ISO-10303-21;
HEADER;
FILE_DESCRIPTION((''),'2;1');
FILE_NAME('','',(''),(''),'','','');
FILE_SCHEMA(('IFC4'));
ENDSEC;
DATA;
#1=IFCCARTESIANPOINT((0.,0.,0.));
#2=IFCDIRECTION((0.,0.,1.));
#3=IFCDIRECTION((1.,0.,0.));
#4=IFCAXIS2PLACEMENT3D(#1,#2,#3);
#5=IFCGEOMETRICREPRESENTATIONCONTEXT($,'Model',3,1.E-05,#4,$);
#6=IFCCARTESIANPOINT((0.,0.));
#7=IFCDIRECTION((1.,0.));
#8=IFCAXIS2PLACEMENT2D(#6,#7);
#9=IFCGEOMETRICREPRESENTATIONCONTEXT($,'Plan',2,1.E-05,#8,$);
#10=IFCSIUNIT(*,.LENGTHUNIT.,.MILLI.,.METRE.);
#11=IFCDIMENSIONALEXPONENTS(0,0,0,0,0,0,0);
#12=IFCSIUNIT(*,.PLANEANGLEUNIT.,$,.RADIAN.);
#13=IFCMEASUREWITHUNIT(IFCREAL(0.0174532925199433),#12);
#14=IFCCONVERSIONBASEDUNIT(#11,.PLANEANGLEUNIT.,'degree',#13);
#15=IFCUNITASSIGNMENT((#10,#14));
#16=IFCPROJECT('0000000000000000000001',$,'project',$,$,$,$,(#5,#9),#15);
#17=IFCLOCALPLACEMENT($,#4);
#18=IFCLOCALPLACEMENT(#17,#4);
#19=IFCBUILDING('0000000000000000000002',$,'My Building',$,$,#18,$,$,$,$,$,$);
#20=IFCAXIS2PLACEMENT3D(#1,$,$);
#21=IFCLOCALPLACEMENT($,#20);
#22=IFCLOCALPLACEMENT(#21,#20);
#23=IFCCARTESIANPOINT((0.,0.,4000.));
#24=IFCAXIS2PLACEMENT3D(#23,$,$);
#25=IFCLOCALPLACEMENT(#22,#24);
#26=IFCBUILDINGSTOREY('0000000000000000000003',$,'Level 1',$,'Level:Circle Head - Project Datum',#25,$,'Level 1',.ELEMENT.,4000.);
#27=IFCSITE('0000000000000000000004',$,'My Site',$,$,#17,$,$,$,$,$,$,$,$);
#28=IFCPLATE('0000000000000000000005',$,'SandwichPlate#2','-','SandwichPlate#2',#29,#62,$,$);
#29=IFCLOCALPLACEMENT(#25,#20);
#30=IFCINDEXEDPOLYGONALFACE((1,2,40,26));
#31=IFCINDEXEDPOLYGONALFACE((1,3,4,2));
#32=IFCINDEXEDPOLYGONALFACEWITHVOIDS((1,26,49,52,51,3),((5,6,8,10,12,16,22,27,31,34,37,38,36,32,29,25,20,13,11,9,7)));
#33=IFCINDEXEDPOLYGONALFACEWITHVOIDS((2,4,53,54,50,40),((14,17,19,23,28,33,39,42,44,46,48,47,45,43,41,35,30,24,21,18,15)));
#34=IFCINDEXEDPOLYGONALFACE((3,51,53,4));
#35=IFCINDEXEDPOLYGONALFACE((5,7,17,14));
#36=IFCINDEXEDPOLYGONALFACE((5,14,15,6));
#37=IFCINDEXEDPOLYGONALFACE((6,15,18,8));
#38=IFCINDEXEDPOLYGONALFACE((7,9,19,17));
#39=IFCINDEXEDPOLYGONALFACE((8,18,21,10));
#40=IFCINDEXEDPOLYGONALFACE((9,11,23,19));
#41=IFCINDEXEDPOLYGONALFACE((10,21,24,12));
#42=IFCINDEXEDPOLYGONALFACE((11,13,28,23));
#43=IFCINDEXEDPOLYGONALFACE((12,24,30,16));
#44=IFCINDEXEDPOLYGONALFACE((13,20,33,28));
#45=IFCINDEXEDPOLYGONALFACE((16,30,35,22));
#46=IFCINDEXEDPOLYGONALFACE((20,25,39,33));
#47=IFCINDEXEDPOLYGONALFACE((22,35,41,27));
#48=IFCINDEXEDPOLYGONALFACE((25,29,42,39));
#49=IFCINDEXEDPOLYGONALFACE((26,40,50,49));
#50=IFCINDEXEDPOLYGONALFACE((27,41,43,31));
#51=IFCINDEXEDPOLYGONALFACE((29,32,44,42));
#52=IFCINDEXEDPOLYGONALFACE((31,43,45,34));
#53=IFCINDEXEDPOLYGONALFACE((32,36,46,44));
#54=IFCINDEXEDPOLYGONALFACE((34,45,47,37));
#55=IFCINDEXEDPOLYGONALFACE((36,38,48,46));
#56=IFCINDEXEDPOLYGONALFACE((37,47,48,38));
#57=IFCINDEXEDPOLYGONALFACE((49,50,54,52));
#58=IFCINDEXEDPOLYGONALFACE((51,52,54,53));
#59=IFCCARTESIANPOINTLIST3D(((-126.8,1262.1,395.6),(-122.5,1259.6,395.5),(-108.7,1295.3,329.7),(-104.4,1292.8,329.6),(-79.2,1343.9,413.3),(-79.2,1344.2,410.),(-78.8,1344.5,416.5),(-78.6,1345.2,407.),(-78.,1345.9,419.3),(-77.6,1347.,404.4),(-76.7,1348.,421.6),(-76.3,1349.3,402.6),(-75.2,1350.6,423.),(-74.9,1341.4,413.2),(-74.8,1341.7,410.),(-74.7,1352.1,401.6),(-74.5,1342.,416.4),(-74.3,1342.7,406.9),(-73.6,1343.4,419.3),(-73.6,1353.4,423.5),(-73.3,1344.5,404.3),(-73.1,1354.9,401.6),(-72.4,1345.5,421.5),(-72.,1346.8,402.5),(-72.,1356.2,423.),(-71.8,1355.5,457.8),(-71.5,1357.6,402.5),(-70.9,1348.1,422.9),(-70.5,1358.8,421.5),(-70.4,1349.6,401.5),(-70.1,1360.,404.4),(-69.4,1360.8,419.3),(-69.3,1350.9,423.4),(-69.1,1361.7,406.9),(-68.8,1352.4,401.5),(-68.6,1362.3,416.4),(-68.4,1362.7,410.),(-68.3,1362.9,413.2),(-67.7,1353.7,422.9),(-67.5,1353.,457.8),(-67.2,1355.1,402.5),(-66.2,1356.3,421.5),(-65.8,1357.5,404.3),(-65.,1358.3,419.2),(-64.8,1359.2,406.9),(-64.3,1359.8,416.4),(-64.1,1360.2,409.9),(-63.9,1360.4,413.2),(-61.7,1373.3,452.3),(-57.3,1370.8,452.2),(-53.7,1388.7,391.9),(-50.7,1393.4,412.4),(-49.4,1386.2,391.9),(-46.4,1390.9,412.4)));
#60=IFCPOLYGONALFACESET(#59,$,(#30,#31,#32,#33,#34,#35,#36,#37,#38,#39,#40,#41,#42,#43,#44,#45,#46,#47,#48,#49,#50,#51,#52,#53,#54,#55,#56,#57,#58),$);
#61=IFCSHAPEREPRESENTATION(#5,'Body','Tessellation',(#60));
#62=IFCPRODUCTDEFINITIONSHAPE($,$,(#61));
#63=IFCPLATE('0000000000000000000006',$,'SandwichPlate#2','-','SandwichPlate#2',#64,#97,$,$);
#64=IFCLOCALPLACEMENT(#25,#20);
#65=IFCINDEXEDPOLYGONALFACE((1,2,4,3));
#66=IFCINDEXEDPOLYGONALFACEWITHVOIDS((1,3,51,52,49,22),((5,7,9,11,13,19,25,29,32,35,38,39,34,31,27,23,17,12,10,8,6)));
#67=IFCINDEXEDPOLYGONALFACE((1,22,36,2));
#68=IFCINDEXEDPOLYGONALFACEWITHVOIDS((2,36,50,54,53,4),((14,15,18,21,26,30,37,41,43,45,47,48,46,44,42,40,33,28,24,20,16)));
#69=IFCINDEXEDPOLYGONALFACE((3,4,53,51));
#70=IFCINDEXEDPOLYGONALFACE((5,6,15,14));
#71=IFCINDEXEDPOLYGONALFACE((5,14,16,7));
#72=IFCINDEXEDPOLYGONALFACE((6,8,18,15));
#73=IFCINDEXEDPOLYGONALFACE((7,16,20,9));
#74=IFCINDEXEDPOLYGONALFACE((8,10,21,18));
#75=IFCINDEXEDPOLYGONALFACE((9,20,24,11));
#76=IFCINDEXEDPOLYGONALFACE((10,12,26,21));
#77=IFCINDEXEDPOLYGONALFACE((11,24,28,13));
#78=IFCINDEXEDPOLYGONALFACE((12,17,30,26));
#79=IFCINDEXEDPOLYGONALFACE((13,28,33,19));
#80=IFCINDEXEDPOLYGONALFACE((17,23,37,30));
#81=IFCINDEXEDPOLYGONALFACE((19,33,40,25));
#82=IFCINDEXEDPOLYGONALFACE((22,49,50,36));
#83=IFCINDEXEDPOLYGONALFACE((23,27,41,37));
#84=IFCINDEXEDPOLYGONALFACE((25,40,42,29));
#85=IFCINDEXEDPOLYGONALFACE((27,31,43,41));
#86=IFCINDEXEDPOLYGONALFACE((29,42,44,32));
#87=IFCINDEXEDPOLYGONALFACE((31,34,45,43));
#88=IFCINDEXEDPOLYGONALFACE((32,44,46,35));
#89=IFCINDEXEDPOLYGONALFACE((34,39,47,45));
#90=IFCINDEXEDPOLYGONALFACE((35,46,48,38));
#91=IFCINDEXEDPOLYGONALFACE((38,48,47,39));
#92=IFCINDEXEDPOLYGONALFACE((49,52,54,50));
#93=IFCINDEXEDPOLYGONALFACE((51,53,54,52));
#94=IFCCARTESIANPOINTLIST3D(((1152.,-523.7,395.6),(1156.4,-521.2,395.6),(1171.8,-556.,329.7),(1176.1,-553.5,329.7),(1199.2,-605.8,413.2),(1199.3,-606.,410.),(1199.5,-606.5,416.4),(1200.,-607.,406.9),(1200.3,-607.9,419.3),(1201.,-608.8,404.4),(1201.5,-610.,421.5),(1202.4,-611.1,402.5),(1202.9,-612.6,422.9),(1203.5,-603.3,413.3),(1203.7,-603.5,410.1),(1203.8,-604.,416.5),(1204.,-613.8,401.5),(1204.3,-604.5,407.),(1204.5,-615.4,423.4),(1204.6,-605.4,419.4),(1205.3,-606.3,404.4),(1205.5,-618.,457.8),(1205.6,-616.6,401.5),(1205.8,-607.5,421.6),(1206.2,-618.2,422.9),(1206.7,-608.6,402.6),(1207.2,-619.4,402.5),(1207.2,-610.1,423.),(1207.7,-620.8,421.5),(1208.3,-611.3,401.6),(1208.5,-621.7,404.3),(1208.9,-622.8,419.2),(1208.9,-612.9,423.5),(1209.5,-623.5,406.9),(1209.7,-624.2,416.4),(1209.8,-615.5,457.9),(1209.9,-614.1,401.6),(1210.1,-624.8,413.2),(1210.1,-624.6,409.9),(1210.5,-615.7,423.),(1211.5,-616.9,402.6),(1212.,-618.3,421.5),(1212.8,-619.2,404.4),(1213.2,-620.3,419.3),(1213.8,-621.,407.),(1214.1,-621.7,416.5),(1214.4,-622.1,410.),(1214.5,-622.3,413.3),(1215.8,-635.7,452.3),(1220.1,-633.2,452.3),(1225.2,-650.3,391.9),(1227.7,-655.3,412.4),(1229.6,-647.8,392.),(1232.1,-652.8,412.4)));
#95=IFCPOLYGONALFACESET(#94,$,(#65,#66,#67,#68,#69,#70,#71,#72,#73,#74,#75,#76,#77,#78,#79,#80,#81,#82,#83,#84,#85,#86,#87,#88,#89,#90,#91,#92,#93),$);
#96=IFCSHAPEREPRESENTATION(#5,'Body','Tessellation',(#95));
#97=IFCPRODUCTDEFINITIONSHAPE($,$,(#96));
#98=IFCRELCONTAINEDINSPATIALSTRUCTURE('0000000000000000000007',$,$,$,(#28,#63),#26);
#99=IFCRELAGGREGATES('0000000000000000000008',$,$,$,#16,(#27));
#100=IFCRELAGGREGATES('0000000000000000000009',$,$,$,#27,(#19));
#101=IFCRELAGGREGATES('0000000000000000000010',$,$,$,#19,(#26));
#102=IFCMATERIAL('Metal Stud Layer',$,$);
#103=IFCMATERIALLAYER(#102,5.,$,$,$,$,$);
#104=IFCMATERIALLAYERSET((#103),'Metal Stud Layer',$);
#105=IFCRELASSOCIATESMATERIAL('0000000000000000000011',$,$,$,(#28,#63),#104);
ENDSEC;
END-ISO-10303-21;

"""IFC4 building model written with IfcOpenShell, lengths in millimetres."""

from ifc_helpers import new_model, entity, si_unit, converted_unit, frame, origin, origin_with_axes, origin_2d_with_axis, place, context, project, spatial, polyline, circle, outline, extrude, material, layer, layer_set, element, save


model = new_model("IFC4")

# Units and contexts
model_context = context("Model", 3, precision=1e-05, world=origin_with_axes())
plan_context = context("Plan", 2, precision=1e-05, world=origin_2d_with_axis())
ifc_project = project(units=[si_unit("LENGTHUNIT", "METRE", prefix="MILLI"), converted_unit("PLANEANGLEUNIT", "degree", entity("IfcReal", 0.0174532925199433), si_unit("PLANEANGLEUNIT", "RADIAN"), dimensions=[0, 0, 0, 0, 0, 0, 0])], contexts=[model_context, plan_context])

# Site, building, storey
site_placement = place(None, origin_with_axes())
site = spatial("IfcSite", under=ifc_project, at=site_placement, Name="My Site")
building_placement = place(site_placement, origin_with_axes())
building = spatial("IfcBuilding", under=site, at=building_placement, Name="My Building")
placement_1 = place(None, origin())
placement_2 = place(placement_1, origin())
storey_placement = place(placement_2, frame((0.0, 0.0, 4000.0)))
storey = spatial("IfcBuildingStorey", under=building, at=storey_placement, Name="Level 1", ObjectType="Level:Circle Head - Project Datum", LongName="Level 1", CompositionType="ELEMENT", Elevation=4000.0)

# Plates, openings
ifc_material_1 = material(Name="Metal Stud Layer")
ifc_layer = layer(ifc_material_1, 5.0)
ifc_layer_set = layer_set([ifc_layer], Name="Metal Stud Layer")
plate_1_placement = place(storey_placement, frame((-47.1, 1400.0, 399.4), z_axis=(0.865935, -0.499948, -0.014432), x_axis=(-0.238139, -0.437501, 0.867112)))
plate_1 = element("IfcPlate", 1, at=plate_1_placement, inside=storey, material=ifc_layer_set, Name="SandwichPlate#2", Description="-", ObjectType="SandwichPlate#2", context=model_context, shape_type="SweptSolid", body=[
    extrude(outline(polyline([(0.0, 0.0), (76.0, 0.0), (76.0, 140.0), (0.0, 140.0), (0.0, 0.0)])), origin_with_axes(), (0.0, 0.0, 1.0), 5.0),
])
opening_1_placement = place(plate_1_placement, frame((0.0, 0.0, 0.0), z_axis=(0.0, 0.0, 1.0), x_axis=(1.0, 0.0, 0.0)))
element("IfcOpeningElement", 2, at=opening_1_placement, cuts=plate_1, ObjectType="Opening", context=model_context, shape_type="SweptSolid", body=[
    extrude(outline(polyline([(0.0, 0.0), (15.0, 0.0), (0.0, 15.0), (0.0, 0.0)])), origin(), (0.0, 0.0, 1.0), 5.0),
])
opening_2_placement = place(plate_1_placement, frame((0.0, 0.0, 0.0), z_axis=(0.0, 0.0, 1.0), x_axis=(1.0, 0.0, 0.0)))
element("IfcOpeningElement", 3, at=opening_2_placement, cuts=plate_1, ObjectType="Opening", context=model_context, shape_type="SweptSolid", body=[
    extrude(outline(polyline([(76.0, 0.0), (76.0, 15.0), (61.0, 0.0), (76.0, 0.0)])), origin(), (0.0, 0.0, 1.0), 5.0),
])
opening_3_placement = place(plate_1_placement, frame((38.0, 40.0, -0.5), z_axis=(0.0, 0.0, 1.0), x_axis=(0.0, 1.0, 0.0)))
element("IfcOpeningElement", 4, at=opening_3_placement, cuts=plate_1, ObjectType="Opening", context=model_context, shape_type="SweptSolid", body=[
    extrude(circle(Radius=11.0, at=origin_2d_with_axis()), origin(), (0.0, 0.0, 1.0), 6.0),
])
plate_2_placement = place(storey_placement, frame((1236.0, -659.2, 399.4), z_axis=(-0.865935, -0.499948, -0.014432), x_axis=(-0.259821, 0.424992, 0.867107)))
plate_2 = element("IfcPlate", 5, at=plate_2_placement, inside=storey, material=ifc_layer_set, Name="SandwichPlate#2", Description="-", ObjectType="SandwichPlate#2", context=model_context, shape_type="SweptSolid", body=[
    extrude(outline(polyline([(0.0, 0.0), (76.0, 0.0), (76.0, 140.0), (0.0, 140.0), (0.0, 0.0)])), origin_with_axes(), (0.0, 0.0, 1.0), 5.0),
])
opening_4_placement = place(plate_2_placement, frame((0.0, 0.0, 0.0), z_axis=(0.0, 0.0, 1.0), x_axis=(1.0, 0.0, 0.0)))
element("IfcOpeningElement", 6, at=opening_4_placement, cuts=plate_2, ObjectType="Opening", context=model_context, shape_type="SweptSolid", body=[
    extrude(outline(polyline([(0.0, 0.0), (15.0, 0.0), (0.0, 15.0), (0.0, 0.0)])), origin(), (0.0, 0.0, 1.0), 5.0),
])
opening_5_placement = place(plate_2_placement, frame((0.0, 0.0, 0.0), z_axis=(0.0, 0.0, 1.0), x_axis=(1.0, 0.0, 0.0)))
element("IfcOpeningElement", 7, at=opening_5_placement, cuts=plate_2, ObjectType="Opening", context=model_context, shape_type="SweptSolid", body=[
    extrude(outline(polyline([(76.0, 0.0), (76.0, 15.0), (61.0, 0.0), (76.0, 0.0)])), origin(), (0.0, 0.0, 1.0), 5.0),
])
opening_6_placement = place(plate_2_placement, frame((38.0, 40.0, -0.5), z_axis=(0.0, 0.0, 1.0), x_axis=(0.0, 1.0, 0.0)))
element("IfcOpeningElement", 8, at=opening_6_placement, cuts=plate_2, ObjectType="Opening", context=model_context, shape_type="SweptSolid", body=[
    extrude(circle(Radius=11.0, at=origin_2d_with_axis()), origin(), (0.0, 0.0, 1.0), 6.0),
])

save(model, "model.ifc")
